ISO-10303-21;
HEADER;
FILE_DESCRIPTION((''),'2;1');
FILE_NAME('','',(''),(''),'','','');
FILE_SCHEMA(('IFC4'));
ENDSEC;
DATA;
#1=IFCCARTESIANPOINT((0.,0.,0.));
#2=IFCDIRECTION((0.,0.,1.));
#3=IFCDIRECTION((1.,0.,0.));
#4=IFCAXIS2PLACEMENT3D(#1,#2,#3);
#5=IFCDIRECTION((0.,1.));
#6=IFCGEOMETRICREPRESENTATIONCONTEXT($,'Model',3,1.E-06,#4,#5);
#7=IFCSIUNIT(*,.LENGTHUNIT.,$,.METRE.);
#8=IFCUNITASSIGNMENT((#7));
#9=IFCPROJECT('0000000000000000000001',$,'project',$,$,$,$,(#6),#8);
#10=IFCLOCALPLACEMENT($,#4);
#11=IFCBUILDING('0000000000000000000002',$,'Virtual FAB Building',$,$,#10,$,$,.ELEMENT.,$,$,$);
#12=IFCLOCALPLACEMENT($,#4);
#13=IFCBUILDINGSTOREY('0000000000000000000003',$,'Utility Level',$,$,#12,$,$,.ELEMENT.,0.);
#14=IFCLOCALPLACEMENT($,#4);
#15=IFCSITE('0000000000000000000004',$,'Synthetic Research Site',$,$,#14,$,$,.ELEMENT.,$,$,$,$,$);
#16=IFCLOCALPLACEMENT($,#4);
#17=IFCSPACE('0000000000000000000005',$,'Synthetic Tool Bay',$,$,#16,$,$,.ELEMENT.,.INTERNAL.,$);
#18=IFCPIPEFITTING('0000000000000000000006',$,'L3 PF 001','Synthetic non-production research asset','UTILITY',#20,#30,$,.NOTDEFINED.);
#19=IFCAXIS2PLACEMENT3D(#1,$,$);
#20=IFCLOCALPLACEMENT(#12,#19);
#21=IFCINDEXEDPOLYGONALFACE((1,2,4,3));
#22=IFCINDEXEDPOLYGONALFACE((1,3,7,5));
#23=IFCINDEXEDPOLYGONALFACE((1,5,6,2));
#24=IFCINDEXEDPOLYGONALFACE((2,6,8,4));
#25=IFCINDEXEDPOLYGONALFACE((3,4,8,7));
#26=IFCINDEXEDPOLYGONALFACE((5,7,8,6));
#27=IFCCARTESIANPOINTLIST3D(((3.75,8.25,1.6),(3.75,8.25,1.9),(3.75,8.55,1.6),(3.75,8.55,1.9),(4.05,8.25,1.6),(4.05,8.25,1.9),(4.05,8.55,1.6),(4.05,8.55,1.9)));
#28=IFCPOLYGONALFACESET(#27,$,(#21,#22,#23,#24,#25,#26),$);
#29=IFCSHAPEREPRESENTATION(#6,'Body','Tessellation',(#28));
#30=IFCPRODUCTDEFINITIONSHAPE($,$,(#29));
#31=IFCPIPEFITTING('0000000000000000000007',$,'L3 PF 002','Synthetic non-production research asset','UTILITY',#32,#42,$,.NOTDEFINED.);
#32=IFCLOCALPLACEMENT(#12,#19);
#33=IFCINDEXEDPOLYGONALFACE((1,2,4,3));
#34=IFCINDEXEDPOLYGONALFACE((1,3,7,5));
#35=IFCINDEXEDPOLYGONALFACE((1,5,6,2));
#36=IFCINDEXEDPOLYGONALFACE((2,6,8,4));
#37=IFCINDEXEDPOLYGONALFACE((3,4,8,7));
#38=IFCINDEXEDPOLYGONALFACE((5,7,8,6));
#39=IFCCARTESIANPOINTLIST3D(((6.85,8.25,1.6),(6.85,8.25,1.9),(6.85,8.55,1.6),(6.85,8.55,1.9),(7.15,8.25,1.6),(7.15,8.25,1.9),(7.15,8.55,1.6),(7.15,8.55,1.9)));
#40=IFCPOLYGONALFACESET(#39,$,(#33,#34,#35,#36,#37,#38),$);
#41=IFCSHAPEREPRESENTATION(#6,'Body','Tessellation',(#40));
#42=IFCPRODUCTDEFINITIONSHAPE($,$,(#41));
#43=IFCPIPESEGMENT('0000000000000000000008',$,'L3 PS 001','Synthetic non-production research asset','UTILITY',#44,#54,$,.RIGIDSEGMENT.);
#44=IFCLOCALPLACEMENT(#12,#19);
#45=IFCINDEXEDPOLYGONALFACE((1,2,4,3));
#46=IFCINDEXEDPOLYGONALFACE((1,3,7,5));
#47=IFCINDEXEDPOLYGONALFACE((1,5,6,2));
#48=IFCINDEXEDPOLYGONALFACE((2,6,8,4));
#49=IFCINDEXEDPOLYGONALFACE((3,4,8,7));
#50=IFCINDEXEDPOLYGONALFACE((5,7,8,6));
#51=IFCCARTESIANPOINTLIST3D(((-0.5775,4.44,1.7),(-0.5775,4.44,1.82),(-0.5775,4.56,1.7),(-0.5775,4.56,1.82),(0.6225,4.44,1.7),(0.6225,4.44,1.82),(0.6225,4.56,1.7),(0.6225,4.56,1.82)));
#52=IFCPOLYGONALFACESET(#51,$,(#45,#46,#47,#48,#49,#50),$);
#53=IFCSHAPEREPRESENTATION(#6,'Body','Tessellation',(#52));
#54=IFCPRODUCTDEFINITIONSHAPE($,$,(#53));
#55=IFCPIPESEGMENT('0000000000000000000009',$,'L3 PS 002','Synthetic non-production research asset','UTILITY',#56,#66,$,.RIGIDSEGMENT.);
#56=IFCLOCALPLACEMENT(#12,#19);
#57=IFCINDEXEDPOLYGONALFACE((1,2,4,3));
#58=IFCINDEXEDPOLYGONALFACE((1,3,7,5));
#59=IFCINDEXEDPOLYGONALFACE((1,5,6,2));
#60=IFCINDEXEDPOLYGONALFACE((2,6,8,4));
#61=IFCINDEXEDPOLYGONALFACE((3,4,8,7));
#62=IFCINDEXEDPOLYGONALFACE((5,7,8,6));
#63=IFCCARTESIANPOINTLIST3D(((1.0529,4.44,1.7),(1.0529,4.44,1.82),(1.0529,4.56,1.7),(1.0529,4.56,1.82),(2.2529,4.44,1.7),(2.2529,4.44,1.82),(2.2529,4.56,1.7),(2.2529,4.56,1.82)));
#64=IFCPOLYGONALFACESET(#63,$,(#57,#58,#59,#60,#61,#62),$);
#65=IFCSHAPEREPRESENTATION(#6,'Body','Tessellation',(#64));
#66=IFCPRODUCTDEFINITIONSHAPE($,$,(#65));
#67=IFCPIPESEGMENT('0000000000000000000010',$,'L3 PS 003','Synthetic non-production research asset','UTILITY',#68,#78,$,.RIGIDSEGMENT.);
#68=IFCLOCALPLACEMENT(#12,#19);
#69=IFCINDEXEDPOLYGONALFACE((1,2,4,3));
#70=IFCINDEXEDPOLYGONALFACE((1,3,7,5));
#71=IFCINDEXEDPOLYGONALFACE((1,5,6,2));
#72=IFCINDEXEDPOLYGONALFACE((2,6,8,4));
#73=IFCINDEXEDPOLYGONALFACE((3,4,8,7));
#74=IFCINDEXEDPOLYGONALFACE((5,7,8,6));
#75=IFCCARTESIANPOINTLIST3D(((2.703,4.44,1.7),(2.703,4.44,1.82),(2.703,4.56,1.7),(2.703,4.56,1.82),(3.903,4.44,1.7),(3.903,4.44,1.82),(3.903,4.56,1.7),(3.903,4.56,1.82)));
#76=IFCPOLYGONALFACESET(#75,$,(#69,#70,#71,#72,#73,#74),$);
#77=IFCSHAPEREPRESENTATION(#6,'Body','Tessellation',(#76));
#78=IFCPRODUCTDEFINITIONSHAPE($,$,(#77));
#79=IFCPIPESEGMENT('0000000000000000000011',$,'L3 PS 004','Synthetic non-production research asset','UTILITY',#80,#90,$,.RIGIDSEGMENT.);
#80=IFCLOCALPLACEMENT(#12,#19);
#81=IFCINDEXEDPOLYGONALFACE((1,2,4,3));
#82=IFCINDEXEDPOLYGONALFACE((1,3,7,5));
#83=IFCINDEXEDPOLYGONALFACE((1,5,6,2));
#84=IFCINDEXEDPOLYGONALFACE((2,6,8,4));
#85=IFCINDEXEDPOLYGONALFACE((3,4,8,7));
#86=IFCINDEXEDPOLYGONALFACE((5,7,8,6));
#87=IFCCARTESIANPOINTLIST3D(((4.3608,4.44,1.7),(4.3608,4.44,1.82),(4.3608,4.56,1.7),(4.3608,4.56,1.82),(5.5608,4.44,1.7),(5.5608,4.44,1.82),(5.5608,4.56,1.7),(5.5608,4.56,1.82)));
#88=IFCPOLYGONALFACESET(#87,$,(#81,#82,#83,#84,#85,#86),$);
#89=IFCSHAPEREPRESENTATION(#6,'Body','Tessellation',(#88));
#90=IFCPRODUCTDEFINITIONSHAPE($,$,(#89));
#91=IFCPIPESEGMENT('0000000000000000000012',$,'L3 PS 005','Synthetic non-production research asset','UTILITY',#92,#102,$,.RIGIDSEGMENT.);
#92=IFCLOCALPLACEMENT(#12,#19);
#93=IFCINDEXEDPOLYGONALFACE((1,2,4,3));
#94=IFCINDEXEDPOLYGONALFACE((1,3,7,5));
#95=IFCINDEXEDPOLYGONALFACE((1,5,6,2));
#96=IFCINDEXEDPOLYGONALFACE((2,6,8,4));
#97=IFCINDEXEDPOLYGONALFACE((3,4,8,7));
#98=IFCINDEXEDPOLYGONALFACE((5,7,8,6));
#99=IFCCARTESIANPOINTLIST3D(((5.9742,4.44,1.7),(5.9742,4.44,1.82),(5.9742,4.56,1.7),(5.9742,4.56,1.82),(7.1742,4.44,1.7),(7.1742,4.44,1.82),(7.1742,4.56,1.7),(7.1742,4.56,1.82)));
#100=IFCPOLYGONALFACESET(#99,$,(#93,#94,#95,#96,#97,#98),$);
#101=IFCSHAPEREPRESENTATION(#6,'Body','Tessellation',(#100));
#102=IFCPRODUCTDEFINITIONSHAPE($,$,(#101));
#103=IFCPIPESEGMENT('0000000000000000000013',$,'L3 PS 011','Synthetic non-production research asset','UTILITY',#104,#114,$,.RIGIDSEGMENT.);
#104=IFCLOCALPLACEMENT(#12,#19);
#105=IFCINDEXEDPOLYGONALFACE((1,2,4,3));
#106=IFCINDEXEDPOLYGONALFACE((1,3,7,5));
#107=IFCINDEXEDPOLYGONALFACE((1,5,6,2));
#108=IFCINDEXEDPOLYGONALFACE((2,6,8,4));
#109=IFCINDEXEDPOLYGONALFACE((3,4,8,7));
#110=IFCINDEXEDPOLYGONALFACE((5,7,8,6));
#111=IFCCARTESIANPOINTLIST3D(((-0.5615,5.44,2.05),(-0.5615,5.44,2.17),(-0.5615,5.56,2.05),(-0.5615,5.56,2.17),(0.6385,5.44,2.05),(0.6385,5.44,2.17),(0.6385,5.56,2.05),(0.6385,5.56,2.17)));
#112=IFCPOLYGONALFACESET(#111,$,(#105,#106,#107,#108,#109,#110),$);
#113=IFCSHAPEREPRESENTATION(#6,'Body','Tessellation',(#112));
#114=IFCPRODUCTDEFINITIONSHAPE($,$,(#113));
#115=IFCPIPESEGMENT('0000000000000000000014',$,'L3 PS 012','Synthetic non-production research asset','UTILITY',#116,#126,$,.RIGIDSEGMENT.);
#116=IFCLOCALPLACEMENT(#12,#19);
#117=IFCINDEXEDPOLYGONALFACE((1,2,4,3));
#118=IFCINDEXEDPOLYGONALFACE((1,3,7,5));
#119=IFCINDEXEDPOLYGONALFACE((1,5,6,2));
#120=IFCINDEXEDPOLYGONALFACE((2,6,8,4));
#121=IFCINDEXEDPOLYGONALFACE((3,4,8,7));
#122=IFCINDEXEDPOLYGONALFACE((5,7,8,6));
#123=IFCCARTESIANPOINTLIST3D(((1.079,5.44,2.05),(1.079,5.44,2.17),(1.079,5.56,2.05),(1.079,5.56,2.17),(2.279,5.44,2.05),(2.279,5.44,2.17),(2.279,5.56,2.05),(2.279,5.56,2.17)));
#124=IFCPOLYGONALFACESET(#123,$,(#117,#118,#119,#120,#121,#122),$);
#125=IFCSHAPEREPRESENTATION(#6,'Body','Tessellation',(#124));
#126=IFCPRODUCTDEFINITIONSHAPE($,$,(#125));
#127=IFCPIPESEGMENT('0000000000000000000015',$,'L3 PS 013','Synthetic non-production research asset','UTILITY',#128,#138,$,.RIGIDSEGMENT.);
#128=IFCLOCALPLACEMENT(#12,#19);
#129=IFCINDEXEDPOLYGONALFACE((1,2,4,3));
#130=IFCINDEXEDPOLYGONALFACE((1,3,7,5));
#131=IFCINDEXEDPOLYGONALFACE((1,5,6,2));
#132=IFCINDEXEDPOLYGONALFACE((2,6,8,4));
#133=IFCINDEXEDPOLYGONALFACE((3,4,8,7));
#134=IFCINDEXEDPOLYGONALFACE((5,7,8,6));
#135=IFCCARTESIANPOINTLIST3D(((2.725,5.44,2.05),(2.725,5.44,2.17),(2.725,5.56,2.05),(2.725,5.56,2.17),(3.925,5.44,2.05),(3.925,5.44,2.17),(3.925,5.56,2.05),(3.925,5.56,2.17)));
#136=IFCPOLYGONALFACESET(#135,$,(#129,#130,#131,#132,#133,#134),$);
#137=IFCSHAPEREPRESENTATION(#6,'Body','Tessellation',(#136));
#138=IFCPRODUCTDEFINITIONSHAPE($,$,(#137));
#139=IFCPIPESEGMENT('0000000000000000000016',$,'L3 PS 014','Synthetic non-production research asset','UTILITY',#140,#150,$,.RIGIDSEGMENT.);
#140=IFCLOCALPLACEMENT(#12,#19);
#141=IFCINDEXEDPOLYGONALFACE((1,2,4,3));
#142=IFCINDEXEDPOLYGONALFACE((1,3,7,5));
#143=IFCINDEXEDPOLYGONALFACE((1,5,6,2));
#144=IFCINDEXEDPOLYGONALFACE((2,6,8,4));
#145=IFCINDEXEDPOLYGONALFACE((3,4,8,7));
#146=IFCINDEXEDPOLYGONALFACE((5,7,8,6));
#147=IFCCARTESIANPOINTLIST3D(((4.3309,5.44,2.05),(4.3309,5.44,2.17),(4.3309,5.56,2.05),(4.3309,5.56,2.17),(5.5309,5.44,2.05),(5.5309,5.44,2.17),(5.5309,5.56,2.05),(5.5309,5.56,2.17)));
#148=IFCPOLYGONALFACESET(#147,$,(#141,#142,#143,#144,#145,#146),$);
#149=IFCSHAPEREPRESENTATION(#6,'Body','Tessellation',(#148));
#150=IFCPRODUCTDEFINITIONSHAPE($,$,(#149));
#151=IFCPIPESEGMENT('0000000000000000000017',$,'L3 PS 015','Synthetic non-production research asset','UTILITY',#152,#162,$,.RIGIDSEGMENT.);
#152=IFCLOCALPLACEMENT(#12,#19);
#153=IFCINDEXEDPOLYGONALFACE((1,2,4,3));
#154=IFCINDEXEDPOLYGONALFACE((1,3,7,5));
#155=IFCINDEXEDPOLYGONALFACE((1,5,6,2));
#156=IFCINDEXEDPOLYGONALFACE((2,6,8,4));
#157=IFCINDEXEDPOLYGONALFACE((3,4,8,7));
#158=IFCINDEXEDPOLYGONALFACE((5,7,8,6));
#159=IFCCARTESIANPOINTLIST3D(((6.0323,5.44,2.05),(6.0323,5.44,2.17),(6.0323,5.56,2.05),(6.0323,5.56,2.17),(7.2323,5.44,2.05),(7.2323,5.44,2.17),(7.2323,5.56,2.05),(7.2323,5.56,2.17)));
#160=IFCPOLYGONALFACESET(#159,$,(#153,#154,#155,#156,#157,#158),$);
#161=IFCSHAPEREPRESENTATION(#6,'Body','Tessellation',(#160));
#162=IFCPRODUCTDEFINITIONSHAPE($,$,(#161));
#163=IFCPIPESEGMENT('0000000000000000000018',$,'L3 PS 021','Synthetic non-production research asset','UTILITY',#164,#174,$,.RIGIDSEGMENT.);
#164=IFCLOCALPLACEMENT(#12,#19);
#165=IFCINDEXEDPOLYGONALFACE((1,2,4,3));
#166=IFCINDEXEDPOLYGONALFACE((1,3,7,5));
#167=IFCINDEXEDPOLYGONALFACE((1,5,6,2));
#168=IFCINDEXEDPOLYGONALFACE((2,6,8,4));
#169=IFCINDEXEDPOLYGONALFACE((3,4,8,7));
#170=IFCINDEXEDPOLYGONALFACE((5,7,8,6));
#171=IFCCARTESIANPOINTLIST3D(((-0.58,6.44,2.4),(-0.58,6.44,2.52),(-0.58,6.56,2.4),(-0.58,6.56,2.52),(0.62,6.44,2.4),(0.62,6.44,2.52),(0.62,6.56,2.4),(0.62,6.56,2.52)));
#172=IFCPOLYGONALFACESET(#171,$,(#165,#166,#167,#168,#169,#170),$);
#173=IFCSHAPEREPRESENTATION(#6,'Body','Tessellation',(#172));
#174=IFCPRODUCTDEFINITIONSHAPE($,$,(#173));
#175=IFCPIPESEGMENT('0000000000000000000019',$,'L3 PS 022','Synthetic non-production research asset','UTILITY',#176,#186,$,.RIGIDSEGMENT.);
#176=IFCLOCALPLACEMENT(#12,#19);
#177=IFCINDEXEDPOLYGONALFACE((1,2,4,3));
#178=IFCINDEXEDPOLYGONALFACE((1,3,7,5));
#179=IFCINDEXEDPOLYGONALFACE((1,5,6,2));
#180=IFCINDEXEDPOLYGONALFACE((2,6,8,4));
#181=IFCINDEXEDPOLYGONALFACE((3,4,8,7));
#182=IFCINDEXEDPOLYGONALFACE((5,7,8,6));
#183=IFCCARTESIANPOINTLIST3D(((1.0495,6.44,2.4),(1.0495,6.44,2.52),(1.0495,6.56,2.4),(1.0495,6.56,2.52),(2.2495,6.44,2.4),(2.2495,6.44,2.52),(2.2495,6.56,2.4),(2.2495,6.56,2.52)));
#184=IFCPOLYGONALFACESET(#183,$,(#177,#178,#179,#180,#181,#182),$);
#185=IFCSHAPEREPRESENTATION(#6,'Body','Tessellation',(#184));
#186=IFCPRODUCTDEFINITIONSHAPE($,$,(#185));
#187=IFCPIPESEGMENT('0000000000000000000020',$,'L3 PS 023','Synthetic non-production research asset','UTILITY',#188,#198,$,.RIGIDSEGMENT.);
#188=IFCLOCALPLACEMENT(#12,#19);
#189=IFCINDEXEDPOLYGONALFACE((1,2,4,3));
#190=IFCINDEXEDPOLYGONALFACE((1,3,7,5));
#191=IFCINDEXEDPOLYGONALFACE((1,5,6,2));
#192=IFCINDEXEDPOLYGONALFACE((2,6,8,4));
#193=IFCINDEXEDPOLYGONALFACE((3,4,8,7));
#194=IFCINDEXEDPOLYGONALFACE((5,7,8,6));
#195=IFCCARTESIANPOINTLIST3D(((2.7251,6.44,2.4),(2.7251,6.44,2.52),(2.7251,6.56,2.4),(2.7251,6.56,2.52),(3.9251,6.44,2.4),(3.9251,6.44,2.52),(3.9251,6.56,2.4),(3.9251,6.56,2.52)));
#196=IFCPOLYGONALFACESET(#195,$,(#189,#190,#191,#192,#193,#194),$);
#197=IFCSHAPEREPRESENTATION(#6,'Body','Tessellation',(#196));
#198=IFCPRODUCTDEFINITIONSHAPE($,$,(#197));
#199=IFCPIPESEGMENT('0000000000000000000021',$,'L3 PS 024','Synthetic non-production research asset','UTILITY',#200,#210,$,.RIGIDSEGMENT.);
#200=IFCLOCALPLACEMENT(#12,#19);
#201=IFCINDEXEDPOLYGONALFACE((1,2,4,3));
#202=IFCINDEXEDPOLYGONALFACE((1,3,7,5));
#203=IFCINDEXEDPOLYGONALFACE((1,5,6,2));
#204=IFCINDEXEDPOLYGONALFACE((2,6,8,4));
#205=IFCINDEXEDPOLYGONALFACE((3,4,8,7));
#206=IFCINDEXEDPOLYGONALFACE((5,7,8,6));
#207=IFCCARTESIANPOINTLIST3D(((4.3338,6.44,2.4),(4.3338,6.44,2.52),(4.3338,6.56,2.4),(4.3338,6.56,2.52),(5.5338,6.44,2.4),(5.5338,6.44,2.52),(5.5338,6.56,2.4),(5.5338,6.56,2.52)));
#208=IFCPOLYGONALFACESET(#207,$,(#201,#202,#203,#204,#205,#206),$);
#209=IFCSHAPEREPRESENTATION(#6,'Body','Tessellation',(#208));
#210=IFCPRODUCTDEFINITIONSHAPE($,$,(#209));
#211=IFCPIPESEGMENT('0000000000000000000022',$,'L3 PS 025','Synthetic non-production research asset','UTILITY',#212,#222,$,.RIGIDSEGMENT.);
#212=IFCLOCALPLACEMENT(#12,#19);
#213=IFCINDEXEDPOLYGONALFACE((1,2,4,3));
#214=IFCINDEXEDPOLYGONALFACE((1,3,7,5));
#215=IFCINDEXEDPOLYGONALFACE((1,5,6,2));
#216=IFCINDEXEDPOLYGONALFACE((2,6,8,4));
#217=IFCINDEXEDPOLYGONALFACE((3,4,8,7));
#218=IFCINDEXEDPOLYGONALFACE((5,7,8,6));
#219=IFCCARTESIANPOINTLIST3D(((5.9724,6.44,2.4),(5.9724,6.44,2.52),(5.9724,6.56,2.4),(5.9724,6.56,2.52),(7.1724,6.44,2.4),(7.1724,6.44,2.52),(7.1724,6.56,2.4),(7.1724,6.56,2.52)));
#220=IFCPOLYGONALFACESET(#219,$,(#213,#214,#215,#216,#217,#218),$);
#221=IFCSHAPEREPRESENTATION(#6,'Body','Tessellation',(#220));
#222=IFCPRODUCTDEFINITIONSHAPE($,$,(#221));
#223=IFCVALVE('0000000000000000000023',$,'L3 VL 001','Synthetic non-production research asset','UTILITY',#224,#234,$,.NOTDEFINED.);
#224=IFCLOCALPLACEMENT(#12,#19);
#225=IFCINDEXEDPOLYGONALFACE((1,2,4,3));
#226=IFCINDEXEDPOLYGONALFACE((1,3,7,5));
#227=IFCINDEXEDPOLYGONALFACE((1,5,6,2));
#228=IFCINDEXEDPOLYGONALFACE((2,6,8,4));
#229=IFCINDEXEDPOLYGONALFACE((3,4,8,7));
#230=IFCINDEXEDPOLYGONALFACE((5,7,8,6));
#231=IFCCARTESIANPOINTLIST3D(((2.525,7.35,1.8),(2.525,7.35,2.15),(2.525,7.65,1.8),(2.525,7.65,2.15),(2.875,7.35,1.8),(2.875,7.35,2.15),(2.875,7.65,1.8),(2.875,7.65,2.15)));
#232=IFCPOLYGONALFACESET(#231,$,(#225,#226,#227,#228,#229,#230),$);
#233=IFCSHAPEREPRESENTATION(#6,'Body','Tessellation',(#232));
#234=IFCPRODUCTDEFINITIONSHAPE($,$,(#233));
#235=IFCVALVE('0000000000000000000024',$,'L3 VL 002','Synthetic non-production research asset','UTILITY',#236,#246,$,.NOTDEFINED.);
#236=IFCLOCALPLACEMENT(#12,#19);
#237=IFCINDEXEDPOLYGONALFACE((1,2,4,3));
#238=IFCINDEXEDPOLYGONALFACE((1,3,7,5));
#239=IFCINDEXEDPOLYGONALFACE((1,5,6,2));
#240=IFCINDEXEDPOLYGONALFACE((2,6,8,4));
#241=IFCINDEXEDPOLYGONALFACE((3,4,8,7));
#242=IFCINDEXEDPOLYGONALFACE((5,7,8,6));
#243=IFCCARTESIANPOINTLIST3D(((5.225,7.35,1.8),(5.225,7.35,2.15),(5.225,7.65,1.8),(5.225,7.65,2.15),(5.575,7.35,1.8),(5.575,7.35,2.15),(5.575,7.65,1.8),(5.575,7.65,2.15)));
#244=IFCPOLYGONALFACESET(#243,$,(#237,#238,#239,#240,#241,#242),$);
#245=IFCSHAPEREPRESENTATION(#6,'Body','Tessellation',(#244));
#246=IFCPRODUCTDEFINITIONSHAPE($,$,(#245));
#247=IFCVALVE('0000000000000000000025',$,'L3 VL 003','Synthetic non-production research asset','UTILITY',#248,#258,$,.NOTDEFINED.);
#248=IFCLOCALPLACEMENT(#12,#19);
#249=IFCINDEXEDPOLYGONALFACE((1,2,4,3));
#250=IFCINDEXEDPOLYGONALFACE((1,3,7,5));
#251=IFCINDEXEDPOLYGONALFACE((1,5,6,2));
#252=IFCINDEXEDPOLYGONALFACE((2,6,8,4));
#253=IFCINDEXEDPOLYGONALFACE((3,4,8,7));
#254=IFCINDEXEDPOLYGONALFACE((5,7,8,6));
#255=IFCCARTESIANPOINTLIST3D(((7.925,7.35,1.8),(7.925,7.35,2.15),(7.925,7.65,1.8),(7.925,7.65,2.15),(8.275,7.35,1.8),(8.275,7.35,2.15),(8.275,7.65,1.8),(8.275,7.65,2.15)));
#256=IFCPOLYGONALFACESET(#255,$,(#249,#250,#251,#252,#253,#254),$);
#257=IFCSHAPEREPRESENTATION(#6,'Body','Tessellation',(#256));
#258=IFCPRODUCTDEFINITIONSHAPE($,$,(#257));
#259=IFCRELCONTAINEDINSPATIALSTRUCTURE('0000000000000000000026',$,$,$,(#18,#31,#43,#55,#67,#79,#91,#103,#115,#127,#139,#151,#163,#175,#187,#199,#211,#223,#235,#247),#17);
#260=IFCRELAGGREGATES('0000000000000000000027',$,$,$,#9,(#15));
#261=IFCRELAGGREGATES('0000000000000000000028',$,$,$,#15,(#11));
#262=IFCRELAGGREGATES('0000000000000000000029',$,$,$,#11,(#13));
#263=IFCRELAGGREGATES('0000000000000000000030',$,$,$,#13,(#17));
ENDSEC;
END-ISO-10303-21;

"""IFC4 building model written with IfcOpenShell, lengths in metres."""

from ifc_helpers import new_model, si_unit, direction, frame, origin_with_axes, origin_2d_with_axis, place, context, project, spatial, rectangle, extrude, element, save


model = new_model("IFC4")

# Units and contexts
model_context = context("Model", 3, precision=1e-06, world=origin_with_axes(), true_north=direction((0.0, 1.0)))
ifc_project = project(units=[si_unit("LENGTHUNIT", "METRE")], contexts=[model_context])

# Site, building, storey, space
site_placement = place(None, origin_with_axes())
site = spatial("IfcSite", under=ifc_project, at=site_placement, Name="Synthetic Research Site", CompositionType="ELEMENT")
building_placement = place(None, origin_with_axes())
building = spatial("IfcBuilding", under=site, at=building_placement, Name="Virtual FAB Building", CompositionType="ELEMENT")
storey_placement = place(None, origin_with_axes())
storey = spatial("IfcBuildingStorey", under=building, at=storey_placement, Name="Utility Level", CompositionType="ELEMENT", Elevation=0.0)
space_placement = place(None, origin_with_axes())
space = spatial("IfcSpace", under=storey, at=space_placement, Name="Synthetic Tool Bay", CompositionType="ELEMENT", PredefinedType="INTERNAL")

# Pipe fittings
for number, where, z_axis, x_axis, name in (
    (1, (3.9, 8.4, 1.6), (0.0, 0.0, 1.0), (1.0, 0.0, 0.0), "L3 PF 001"),
    (2, (7.0, 8.4, 1.6), (0.0, 0.0, 1.0), (1.0, 0.0, 0.0), "L3 PF 002"),
):
    element("IfcPipeFitting", number, at=place(None, frame(where, z_axis=z_axis, x_axis=x_axis)), inside=space, Name=name, Description="Synthetic non-production research asset", ObjectType="UTILITY", PredefinedType="NOTDEFINED", context=model_context, shape_type="SweptSolid", body=[
        extrude(rectangle(XDim=0.3, YDim=0.3, at=origin_2d_with_axis()), origin_with_axes(), (0.0, 0.0, 1.0), 0.3),
    ])

# Pipe segments
for number, where, z_axis, x_axis, name in (
    (3, (0.0225, 4.5, 1.7), (0.0, 0.0, 1.0), (1.0, 0.0, 0.0), "L3 PS 001"),
    (4, (1.6529, 4.5, 1.7), (0.0, 0.0, 1.0), (1.0, 0.0, 0.0), "L3 PS 002"),
    (5, (3.303, 4.5, 1.7), (0.0, 0.0, 1.0), (1.0, 0.0, 0.0), "L3 PS 003"),
    (6, (4.9608, 4.5, 1.7), (0.0, 0.0, 1.0), (1.0, 0.0, 0.0), "L3 PS 004"),
    (7, (6.5742, 4.5, 1.7), (0.0, 0.0, 1.0), (1.0, 0.0, 0.0), "L3 PS 005"),
    (8, (0.0385, 5.5, 2.05), (0.0, 0.0, 1.0), (1.0, 0.0, 0.0), "L3 PS 011"),
    (9, (1.679, 5.5, 2.05), (0.0, 0.0, 1.0), (1.0, 0.0, 0.0), "L3 PS 012"),
    (10, (3.325, 5.5, 2.05), (0.0, 0.0, 1.0), (1.0, 0.0, 0.0), "L3 PS 013"),
    (11, (4.9309, 5.5, 2.05), (0.0, 0.0, 1.0), (1.0, 0.0, 0.0), "L3 PS 014"),
    (12, (6.6323, 5.5, 2.05), (0.0, 0.0, 1.0), (1.0, 0.0, 0.0), "L3 PS 015"),
    (13, (0.02, 6.5, 2.4), (0.0, 0.0, 1.0), (1.0, 0.0, 0.0), "L3 PS 021"),
    (14, (1.6495, 6.5, 2.4), (0.0, 0.0, 1.0), (1.0, 0.0, 0.0), "L3 PS 022"),
    (15, (3.3251, 6.5, 2.4), (0.0, 0.0, 1.0), (1.0, 0.0, 0.0), "L3 PS 023"),
    (16, (4.9338, 6.5, 2.4), (0.0, 0.0, 1.0), (1.0, 0.0, 0.0), "L3 PS 024"),
    (17, (6.5724, 6.5, 2.4), (0.0, 0.0, 1.0), (1.0, 0.0, 0.0), "L3 PS 025"),
):
    element("IfcPipeSegment", number, at=place(None, frame(where, z_axis=z_axis, x_axis=x_axis)), inside=space, Name=name, Description="Synthetic non-production research asset", ObjectType="UTILITY", PredefinedType="RIGIDSEGMENT", context=model_context, shape_type="SweptSolid", body=[
        extrude(rectangle(XDim=1.2, YDim=0.12, at=origin_2d_with_axis()), origin_with_axes(), (0.0, 0.0, 1.0), 0.12),
    ])

# Valves
for number, where, z_axis, x_axis, name in (
    (18, (2.7, 7.5, 1.8), (0.0, 0.0, 1.0), (1.0, 0.0, 0.0), "L3 VL 001"),
    (19, (5.4, 7.5, 1.8), (0.0, 0.0, 1.0), (1.0, 0.0, 0.0), "L3 VL 002"),
    (20, (8.1, 7.5, 1.8), (0.0, 0.0, 1.0), (1.0, 0.0, 0.0), "L3 VL 003"),
):
    element("IfcValve", number, at=place(None, frame(where, z_axis=z_axis, x_axis=x_axis)), inside=space, Name=name, Description="Synthetic non-production research asset", ObjectType="UTILITY", PredefinedType="NOTDEFINED", context=model_context, shape_type="SweptSolid", body=[
        extrude(rectangle(XDim=0.35, YDim=0.3, at=origin_2d_with_axis()), origin_with_axes(), (0.0, 0.0, 1.0), 0.35),
    ])

save(model, "model.ifc")
